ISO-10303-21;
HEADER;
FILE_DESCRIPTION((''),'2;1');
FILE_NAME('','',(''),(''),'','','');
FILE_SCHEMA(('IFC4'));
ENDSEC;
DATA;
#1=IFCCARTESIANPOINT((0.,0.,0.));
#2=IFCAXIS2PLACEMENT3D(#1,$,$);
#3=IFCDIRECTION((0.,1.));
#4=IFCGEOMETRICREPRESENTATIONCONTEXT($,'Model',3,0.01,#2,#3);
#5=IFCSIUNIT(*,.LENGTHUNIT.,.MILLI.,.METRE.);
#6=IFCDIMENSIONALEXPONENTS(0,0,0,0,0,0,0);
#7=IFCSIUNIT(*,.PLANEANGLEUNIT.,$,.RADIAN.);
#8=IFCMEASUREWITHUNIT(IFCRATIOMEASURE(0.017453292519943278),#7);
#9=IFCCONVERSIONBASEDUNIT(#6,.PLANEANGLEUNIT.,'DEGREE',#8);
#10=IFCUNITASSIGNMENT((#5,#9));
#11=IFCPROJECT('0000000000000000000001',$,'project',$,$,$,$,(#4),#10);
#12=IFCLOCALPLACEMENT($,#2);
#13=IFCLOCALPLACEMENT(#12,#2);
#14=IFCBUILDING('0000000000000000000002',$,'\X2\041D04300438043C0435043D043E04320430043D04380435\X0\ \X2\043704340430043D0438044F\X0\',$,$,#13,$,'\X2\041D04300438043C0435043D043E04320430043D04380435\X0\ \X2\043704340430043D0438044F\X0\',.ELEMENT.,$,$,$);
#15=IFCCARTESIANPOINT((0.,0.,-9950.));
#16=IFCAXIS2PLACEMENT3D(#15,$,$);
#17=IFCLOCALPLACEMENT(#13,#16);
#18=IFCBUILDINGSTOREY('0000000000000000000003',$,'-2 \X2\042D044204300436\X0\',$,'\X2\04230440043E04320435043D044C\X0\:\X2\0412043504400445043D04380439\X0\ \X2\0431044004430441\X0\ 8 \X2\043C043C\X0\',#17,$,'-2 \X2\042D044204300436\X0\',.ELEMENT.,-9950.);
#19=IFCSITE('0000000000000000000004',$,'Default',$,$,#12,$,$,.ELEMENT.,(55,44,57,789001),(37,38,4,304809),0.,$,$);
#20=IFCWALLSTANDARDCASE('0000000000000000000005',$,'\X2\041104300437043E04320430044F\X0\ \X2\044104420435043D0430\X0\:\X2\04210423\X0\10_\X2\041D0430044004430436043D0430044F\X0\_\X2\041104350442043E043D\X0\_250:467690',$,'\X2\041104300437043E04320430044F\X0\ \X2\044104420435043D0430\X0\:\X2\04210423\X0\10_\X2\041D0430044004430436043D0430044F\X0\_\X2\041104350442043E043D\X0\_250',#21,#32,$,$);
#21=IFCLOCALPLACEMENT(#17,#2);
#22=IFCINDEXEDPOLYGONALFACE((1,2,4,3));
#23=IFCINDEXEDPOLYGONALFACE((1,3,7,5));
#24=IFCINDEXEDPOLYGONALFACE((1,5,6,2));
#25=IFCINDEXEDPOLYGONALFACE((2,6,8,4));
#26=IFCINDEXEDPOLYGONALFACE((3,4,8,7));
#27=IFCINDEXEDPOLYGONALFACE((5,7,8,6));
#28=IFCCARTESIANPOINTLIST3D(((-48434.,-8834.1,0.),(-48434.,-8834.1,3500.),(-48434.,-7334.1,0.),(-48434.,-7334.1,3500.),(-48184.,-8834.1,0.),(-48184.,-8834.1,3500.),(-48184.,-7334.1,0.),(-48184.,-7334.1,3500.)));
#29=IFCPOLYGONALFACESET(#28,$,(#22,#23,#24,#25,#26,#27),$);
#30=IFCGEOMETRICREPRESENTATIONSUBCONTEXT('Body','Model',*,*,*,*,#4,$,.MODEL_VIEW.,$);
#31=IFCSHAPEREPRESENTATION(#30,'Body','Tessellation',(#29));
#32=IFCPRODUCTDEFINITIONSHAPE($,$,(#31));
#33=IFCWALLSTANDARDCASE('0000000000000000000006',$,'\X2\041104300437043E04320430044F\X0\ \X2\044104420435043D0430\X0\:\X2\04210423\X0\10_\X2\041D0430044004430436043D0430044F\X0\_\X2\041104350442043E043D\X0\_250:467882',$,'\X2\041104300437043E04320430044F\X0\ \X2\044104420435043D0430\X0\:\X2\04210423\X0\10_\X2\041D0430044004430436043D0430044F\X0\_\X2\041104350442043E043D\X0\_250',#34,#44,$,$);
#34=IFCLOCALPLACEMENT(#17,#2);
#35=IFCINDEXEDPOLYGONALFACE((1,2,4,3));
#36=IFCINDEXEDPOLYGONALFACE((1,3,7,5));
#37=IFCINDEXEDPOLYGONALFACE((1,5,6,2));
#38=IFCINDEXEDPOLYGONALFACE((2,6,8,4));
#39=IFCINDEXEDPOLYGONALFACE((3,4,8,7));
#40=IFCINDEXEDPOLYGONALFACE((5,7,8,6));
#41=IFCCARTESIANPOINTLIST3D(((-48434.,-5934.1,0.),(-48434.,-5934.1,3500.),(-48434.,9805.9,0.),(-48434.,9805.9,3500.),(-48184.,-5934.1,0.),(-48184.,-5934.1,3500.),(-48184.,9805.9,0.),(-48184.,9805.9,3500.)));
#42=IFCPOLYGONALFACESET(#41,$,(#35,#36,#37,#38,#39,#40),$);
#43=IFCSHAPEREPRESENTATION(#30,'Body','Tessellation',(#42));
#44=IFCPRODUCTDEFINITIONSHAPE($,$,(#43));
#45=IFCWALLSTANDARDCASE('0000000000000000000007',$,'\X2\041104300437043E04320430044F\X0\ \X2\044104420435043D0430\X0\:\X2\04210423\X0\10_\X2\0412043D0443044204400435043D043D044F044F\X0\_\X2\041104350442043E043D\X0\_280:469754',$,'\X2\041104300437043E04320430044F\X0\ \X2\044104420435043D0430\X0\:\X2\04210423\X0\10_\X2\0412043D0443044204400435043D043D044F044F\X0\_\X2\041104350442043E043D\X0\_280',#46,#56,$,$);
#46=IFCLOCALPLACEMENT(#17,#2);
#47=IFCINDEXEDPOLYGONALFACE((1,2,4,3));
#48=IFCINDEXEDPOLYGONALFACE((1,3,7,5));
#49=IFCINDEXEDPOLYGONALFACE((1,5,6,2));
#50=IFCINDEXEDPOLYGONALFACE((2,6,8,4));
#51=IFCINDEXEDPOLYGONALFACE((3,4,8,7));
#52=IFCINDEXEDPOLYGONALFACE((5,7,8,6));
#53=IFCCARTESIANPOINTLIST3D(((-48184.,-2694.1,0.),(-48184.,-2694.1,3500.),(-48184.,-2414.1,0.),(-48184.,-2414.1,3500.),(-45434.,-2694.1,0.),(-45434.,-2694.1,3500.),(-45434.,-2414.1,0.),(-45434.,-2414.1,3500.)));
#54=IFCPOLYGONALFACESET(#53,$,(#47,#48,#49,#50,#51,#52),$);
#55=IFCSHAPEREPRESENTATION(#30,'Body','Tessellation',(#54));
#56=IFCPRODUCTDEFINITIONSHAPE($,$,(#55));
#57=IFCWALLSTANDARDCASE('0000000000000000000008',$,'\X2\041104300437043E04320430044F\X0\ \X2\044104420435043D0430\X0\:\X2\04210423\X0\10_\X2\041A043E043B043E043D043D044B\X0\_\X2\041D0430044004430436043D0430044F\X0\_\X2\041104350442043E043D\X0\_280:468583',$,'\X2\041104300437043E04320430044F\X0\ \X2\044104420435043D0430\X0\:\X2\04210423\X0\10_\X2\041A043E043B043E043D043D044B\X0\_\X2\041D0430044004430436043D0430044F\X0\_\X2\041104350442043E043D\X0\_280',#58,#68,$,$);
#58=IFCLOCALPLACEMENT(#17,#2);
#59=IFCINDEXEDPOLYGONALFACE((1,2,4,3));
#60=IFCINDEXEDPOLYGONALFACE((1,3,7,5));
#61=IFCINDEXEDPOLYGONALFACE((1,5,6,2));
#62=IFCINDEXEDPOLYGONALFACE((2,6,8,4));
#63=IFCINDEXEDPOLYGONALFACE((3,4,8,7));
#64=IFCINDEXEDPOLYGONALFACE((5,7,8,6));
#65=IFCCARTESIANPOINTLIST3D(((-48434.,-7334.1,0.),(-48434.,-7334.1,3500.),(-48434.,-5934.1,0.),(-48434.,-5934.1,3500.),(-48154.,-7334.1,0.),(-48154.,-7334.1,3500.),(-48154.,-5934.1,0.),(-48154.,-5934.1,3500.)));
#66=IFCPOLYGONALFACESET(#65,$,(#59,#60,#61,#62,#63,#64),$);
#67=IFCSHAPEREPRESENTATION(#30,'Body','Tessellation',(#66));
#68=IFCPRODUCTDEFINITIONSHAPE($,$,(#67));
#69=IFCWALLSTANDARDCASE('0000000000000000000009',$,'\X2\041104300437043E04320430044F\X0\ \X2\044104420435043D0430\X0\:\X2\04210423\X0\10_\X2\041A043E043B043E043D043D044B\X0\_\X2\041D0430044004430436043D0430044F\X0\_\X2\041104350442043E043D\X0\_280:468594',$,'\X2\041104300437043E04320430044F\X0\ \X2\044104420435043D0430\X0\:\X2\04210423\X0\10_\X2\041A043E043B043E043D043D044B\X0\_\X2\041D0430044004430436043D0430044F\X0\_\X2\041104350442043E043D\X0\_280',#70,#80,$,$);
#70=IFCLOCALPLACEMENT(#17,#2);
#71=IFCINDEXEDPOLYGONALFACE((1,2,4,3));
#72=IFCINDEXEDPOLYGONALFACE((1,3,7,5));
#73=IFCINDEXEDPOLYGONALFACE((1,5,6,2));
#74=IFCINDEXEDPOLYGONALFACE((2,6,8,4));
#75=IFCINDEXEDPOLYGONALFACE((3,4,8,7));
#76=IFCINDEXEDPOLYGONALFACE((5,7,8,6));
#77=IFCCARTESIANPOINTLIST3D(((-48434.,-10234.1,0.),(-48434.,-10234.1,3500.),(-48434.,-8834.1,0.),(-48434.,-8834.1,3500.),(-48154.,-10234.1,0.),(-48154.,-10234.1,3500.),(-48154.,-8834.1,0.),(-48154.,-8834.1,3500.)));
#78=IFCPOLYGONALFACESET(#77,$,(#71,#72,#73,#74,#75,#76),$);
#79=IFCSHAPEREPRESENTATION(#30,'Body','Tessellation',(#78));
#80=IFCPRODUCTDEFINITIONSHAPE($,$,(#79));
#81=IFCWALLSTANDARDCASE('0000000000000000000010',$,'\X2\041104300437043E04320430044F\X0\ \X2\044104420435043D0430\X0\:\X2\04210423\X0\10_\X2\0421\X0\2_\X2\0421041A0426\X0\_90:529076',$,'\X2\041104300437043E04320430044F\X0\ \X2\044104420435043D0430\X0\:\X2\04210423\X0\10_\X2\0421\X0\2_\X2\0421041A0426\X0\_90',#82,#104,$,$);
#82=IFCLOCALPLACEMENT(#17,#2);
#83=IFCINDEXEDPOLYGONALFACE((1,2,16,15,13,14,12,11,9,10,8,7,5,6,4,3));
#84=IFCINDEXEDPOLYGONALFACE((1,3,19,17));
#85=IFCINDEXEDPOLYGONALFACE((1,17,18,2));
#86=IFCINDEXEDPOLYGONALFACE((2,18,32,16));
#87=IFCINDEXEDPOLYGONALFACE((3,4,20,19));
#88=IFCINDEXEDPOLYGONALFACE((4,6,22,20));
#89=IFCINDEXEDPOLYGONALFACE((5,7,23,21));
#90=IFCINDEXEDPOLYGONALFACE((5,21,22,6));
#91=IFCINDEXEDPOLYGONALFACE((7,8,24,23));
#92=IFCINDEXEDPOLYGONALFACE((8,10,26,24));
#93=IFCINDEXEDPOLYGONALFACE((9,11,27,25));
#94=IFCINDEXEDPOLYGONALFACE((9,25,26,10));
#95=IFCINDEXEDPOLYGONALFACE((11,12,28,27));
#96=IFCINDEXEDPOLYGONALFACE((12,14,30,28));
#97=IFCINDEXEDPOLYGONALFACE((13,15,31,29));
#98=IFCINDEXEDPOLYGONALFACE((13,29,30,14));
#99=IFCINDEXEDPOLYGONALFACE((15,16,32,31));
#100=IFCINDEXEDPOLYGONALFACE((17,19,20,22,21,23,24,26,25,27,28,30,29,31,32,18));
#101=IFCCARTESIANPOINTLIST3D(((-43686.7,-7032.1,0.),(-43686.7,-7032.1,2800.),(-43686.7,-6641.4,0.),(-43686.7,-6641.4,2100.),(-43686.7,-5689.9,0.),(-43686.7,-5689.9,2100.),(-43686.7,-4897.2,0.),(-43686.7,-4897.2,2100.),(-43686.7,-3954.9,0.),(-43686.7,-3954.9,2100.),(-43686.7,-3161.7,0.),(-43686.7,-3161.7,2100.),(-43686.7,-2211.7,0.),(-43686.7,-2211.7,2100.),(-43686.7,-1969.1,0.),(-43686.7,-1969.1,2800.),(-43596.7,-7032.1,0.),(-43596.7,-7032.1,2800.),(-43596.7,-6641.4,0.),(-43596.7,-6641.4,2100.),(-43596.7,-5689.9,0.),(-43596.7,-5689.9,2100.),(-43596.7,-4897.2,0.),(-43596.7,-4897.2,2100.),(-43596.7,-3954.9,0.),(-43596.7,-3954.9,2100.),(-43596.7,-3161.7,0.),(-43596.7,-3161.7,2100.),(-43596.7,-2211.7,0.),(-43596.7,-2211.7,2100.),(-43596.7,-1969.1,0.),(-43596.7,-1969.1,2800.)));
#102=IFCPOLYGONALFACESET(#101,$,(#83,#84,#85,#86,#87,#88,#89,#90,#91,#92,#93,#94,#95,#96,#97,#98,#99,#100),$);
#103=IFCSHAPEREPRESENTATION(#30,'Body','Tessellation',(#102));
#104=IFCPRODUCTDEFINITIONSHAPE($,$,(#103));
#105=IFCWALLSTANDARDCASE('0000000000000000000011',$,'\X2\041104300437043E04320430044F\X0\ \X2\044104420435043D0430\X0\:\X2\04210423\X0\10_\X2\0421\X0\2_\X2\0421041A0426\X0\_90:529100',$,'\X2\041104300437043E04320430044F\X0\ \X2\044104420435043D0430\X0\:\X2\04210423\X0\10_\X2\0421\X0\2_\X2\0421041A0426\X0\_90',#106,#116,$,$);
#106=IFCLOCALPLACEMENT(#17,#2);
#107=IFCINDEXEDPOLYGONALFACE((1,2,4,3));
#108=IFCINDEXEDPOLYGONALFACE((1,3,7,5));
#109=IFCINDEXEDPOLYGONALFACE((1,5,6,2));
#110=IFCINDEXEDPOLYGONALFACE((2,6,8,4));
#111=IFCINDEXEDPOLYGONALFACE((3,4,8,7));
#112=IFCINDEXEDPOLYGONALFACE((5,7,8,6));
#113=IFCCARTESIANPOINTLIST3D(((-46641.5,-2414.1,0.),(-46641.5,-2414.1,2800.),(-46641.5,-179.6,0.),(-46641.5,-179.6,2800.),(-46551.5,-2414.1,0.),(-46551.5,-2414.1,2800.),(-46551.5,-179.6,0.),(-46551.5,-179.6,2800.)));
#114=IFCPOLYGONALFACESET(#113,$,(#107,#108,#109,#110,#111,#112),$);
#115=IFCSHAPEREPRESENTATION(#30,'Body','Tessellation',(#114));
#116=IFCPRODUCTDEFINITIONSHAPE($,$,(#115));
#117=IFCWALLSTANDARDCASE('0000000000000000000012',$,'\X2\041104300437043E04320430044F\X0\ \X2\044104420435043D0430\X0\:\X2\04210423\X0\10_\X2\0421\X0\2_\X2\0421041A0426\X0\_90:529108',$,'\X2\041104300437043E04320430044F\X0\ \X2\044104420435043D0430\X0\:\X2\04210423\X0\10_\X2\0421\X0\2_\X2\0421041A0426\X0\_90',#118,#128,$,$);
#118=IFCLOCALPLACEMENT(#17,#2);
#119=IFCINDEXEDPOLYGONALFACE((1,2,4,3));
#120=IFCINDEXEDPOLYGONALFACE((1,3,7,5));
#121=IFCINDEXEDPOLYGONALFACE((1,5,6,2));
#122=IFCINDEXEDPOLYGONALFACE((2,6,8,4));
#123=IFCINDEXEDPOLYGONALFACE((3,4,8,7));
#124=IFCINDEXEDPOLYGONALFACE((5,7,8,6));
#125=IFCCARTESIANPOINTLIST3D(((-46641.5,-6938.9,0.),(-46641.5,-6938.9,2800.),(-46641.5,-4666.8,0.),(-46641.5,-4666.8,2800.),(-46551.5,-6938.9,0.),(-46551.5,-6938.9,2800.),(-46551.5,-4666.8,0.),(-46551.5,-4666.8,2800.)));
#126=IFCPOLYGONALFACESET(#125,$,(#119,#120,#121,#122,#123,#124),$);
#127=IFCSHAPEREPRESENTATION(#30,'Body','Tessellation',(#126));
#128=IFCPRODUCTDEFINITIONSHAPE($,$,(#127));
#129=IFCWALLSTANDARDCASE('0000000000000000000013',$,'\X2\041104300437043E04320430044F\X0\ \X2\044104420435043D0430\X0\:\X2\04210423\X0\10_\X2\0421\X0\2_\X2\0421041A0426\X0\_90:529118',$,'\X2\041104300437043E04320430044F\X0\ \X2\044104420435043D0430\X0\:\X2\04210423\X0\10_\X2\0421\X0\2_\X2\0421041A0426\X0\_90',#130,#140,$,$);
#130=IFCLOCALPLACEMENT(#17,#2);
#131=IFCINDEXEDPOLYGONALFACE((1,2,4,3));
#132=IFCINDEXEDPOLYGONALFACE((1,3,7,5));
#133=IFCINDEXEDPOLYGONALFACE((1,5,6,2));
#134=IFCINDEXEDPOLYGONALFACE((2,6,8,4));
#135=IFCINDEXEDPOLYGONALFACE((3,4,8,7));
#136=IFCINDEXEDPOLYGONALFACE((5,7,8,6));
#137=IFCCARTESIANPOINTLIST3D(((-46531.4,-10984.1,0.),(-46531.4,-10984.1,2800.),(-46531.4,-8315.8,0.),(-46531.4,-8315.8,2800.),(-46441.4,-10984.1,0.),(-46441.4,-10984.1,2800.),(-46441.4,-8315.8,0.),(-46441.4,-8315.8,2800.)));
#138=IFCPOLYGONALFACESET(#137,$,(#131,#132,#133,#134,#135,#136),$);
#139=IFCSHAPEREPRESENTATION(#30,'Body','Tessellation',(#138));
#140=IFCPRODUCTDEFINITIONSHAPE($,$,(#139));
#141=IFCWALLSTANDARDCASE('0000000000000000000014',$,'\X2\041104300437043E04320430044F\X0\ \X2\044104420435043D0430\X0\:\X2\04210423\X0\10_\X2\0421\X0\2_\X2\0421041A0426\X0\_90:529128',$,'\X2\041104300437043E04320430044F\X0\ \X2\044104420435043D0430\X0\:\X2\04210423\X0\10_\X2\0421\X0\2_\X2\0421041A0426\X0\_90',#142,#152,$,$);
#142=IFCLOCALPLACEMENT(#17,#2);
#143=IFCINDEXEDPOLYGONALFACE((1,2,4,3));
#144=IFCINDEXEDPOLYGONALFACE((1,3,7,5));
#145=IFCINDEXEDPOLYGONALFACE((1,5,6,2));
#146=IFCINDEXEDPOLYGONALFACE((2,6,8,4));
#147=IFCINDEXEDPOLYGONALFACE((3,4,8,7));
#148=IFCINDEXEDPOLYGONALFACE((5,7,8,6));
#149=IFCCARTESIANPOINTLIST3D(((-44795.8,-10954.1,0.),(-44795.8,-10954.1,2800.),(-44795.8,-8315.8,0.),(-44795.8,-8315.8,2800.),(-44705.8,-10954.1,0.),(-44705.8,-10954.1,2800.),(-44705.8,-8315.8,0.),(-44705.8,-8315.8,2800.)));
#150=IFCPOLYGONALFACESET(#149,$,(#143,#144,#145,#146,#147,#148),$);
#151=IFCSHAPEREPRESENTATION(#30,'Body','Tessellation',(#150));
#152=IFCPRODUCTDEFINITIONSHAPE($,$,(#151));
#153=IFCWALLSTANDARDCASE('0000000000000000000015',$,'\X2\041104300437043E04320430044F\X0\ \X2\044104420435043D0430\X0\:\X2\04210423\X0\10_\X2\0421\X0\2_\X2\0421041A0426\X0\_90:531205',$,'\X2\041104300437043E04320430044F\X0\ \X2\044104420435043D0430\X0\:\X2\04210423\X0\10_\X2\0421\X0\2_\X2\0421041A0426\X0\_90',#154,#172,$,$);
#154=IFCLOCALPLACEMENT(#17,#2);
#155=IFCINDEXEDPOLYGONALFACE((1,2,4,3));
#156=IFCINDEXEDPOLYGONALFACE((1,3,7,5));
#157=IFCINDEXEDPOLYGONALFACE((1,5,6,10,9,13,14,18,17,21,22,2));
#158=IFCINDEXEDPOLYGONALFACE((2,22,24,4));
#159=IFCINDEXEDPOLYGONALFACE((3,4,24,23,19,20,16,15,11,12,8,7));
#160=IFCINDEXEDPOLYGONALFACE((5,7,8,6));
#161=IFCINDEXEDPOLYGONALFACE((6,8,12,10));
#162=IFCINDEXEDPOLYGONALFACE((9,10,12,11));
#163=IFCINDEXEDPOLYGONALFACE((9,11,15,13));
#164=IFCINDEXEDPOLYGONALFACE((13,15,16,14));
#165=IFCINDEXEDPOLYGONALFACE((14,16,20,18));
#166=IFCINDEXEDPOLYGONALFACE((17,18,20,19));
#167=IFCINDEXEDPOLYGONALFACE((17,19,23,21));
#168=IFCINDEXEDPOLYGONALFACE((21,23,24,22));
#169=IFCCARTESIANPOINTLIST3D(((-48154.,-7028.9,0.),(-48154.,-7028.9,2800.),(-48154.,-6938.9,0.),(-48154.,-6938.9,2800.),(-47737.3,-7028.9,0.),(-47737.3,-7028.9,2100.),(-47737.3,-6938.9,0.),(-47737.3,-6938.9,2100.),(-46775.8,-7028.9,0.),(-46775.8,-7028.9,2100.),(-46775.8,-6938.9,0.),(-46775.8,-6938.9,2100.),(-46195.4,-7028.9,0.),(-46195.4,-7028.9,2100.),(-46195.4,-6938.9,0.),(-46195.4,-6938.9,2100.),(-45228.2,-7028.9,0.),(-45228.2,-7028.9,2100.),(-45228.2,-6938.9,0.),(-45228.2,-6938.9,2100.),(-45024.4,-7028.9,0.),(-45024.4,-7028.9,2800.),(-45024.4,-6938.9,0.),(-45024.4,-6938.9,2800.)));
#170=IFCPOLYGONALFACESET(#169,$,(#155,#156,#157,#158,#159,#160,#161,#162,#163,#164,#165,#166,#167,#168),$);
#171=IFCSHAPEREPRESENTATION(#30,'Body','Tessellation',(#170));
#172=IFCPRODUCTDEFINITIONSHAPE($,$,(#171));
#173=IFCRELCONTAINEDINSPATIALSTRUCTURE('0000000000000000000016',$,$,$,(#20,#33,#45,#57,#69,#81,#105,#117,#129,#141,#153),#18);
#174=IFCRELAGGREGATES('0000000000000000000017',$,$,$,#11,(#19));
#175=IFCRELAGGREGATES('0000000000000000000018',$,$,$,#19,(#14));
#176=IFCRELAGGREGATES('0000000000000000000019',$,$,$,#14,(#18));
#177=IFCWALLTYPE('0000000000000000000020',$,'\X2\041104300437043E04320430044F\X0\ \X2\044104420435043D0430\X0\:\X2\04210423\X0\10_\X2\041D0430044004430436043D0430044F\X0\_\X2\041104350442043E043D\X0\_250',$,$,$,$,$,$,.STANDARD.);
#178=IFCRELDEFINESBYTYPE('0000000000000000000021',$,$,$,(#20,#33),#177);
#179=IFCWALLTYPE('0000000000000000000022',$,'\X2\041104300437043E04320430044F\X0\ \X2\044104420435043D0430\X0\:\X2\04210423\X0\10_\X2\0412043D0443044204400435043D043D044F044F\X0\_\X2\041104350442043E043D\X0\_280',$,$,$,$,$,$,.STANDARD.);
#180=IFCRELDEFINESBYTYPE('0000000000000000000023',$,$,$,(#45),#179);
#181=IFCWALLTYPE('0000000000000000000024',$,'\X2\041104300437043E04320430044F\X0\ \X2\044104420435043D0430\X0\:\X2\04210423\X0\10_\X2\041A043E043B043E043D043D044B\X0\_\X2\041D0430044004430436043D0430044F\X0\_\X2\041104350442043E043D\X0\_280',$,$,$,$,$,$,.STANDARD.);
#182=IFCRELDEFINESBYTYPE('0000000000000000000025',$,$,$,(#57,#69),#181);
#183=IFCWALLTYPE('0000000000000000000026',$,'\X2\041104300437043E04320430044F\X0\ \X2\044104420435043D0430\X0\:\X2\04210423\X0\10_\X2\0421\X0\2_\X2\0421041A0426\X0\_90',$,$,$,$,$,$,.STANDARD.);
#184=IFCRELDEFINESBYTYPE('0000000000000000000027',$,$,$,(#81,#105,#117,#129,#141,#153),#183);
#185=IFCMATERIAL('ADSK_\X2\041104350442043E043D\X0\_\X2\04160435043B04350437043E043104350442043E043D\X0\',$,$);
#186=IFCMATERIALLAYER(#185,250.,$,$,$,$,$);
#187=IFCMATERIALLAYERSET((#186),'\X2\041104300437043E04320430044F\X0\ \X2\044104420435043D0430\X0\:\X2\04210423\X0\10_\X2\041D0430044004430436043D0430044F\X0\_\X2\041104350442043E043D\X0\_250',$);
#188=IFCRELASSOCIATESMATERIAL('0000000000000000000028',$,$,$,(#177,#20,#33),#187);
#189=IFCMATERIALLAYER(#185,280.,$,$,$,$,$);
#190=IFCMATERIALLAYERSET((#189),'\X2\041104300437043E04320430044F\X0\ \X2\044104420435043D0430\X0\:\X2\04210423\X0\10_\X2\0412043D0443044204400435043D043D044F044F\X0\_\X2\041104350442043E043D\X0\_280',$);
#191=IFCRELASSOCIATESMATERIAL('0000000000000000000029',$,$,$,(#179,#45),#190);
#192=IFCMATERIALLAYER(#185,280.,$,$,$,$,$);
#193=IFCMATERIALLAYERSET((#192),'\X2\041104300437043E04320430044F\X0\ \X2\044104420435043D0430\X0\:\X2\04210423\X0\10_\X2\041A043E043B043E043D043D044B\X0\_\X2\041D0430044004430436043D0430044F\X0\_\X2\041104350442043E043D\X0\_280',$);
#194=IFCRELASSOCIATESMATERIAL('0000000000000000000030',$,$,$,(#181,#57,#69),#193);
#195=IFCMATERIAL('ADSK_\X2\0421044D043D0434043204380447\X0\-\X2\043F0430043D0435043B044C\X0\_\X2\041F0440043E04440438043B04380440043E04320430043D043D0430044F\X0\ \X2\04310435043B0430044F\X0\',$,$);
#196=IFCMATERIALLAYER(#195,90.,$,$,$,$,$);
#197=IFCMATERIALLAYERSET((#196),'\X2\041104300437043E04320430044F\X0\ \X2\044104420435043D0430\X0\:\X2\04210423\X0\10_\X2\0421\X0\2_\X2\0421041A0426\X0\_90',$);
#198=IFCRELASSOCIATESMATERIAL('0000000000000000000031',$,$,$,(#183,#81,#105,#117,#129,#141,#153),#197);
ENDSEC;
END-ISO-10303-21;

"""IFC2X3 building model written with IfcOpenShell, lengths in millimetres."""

from ifc_helpers import new_model, entity, si_unit, converted_unit, direction, frame, frame_2d, origin, place, context, subcontext, project, spatial, rectangle, extrude, material, layer, layer_set, layer_usage, type_object, element, save


model = new_model("IFC2X3")

# Units and contexts
model_context = context("Model", 3, precision=0.01, world=origin(), true_north=direction((0.0, 1.0)))
body_context = subcontext(model_context, "Body", "Model", "MODEL_VIEW")
ifc_project = project(units=[si_unit("LENGTHUNIT", "METRE", prefix="MILLI"), converted_unit("PLANEANGLEUNIT", "DEGREE", entity("IfcRatioMeasure", 0.017453292519943278), si_unit("PLANEANGLEUNIT", "RADIAN"), dimensions=[0, 0, 0, 0, 0, 0, 0])], contexts=[model_context])

# Site, building, storey
site_placement = place(None, origin())
site = spatial("IfcSite", under=ifc_project, at=site_placement, Name="Default", CompositionType="ELEMENT", RefLatitude=(55, 44, 57, 789001), RefLongitude=(37, 38, 4, 304809), RefElevation=0.0)
building_placement = place(site_placement, origin())
building = spatial("IfcBuilding", under=site, at=building_placement, Name="Наименование здания", LongName="Наименование здания", CompositionType="ELEMENT")
storey_placement = place(building_placement, frame((0.0, 0.0, -9950.0)))
storey = spatial("IfcBuildingStorey", under=building, at=storey_placement, Name="-2 Этаж", ObjectType="Уровень:Верхний брус 8 мм", LongName="-2 Этаж", CompositionType="ELEMENT", Elevation=-9950.0)

# Shared definitions
ifc_material_1 = material(Name="ADSK_Бетон_Железобетон")

# Walls
ifc_layer_1 = layer(ifc_material_1, 250.0)
ifc_layer_set_1 = layer_set([ifc_layer_1], Name="Базовая стена:СУ10_Наружная_Бетон_250")
ifc_layer_usage_1 = layer_usage(ifc_layer_set_1, "AXIS2", "NEGATIVE", 125.0)
wall_type_1 = type_object("IfcWallType", Name="Базовая стена:СУ10_Наружная_Бетон_250", PredefinedType="STANDARD", material=ifc_layer_set_1)
wall_1_placement = place(storey_placement, frame((-48309.0, -8834.1, 0.0), z_axis=(0.0, 0.0, 1.0), x_axis=(0.0, 1.0, 0.0)))
element("IfcWallStandardCase", 1, at=wall_1_placement, inside=storey, type_object=wall_type_1, material=ifc_layer_usage_1, Name="Базовая стена:СУ10_Наружная_Бетон_250:467690", ObjectType="Базовая стена:СУ10_Наружная_Бетон_250", context=body_context, shape_type="SweptSolid", body=[
    extrude(rectangle(XDim=1500.0, YDim=250.0, at=frame_2d((750.0, 0.0), x_axis=(-1.0, 0.0))), origin(), (0.0, 0.0, 1.0), 3500.0),
])
wall_2_placement = place(storey_placement, frame((-48309.0, -5934.1, 0.0), z_axis=(0.0, 0.0, 1.0), x_axis=(0.0, 1.0, 0.0)))
element("IfcWallStandardCase", 2, at=wall_2_placement, inside=storey, type_object=wall_type_1, material=ifc_layer_usage_1, Name="Базовая стена:СУ10_Наружная_Бетон_250:467882", ObjectType="Базовая стена:СУ10_Наружная_Бетон_250", context=body_context, shape_type="SweptSolid", body=[
    extrude(rectangle(XDim=15740.0, YDim=250.0, at=frame_2d((7870.0, 0.0), x_axis=(-1.0, 0.0))), origin(), (0.0, 0.0, 1.0), 3500.0),
])
ifc_layer_2 = layer(ifc_material_1, 280.0)
ifc_layer_set_2 = layer_set([ifc_layer_2], Name="Базовая стена:СУ10_Внутренняя_Бетон_280")
ifc_layer_usage_2 = layer_usage(ifc_layer_set_2, "AXIS2", "NEGATIVE", 140.0)
wall_type_2 = type_object("IfcWallType", Name="Базовая стена:СУ10_Внутренняя_Бетон_280", PredefinedType="STANDARD", material=ifc_layer_set_2)
wall_3_placement = place(storey_placement, frame((-45434.0, -2554.1, 0.0), z_axis=(0.0, 0.0, 1.0), x_axis=(-1.0, 0.0, 0.0)))
element("IfcWallStandardCase", 3, at=wall_3_placement, inside=storey, type_object=wall_type_2, material=ifc_layer_usage_2, Name="Базовая стена:СУ10_Внутренняя_Бетон_280:469754", ObjectType="Базовая стена:СУ10_Внутренняя_Бетон_280", context=body_context, shape_type="SweptSolid", body=[
    extrude(rectangle(XDim=2750.0, YDim=280.0, at=frame_2d((1375.0, 0.0), x_axis=(-1.0, 0.0))), origin(), (0.0, 0.0, 1.0), 3500.0),
])
ifc_layer_3 = layer(ifc_material_1, 280.0)
ifc_layer_set_3 = layer_set([ifc_layer_3], Name="Базовая стена:СУ10_Колонны_Наружная_Бетон_280")
ifc_layer_usage_3 = layer_usage(ifc_layer_set_3, "AXIS2", "NEGATIVE", 140.0)
wall_type_3 = type_object("IfcWallType", Name="Базовая стена:СУ10_Колонны_Наружная_Бетон_280", PredefinedType="STANDARD", material=ifc_layer_set_3)
wall_4_placement = place(storey_placement, frame((-48294.0, -7334.1, 0.0), z_axis=(0.0, 0.0, 1.0), x_axis=(0.0, 1.0, 0.0)))
element("IfcWallStandardCase", 4, at=wall_4_placement, inside=storey, type_object=wall_type_3, material=ifc_layer_usage_3, Name="Базовая стена:СУ10_Колонны_Наружная_Бетон_280:468583", ObjectType="Базовая стена:СУ10_Колонны_Наружная_Бетон_280", context=body_context, shape_type="SweptSolid", body=[
    extrude(rectangle(XDim=1400.0, YDim=280.0, at=frame_2d((700.0, 0.0), x_axis=(-1.0, 0.0))), origin(), (0.0, 0.0, 1.0), 3500.0),
])
wall_5_placement = place(storey_placement, frame((-48294.0, -10234.1, 0.0), z_axis=(0.0, 0.0, 1.0), x_axis=(0.0, 1.0, 0.0)))
element("IfcWallStandardCase", 5, at=wall_5_placement, inside=storey, type_object=wall_type_3, material=ifc_layer_usage_3, Name="Базовая стена:СУ10_Колонны_Наружная_Бетон_280:468594", ObjectType="Базовая стена:СУ10_Колонны_Наружная_Бетон_280", context=body_context, shape_type="SweptSolid", body=[
    extrude(rectangle(XDim=1400.0, YDim=280.0, at=frame_2d((700.0, 0.0), x_axis=(-1.0, 0.0))), origin(), (0.0, 0.0, 1.0), 3500.0),
])

# Wall, openings
ifc_material_2 = material(Name="ADSK_Сэндвич-панель_Профилированная белая")
ifc_layer_4 = layer(ifc_material_2, 90.0)
ifc_layer_set_4 = layer_set([ifc_layer_4], Name="Базовая стена:СУ10_С2_СКЦ_90")
ifc_layer_usage_4 = layer_usage(ifc_layer_set_4, "AXIS2", "NEGATIVE", 45.0)
wall_type_4 = type_object("IfcWallType", Name="Базовая стена:СУ10_С2_СКЦ_90", PredefinedType="STANDARD", material=ifc_layer_set_4)
wall_6_placement = place(storey_placement, frame((-43641.7, -1969.1, 0.0), z_axis=(0.0, 0.0, 1.0), x_axis=(0.0, -1.0, 0.0)))
wall_6 = element("IfcWallStandardCase", 6, at=wall_6_placement, inside=storey, type_object=wall_type_4, material=ifc_layer_usage_4, Name="Базовая стена:СУ10_С2_СКЦ_90:529076", ObjectType="Базовая стена:СУ10_С2_СКЦ_90", context=body_context, shape_type="SweptSolid", body=[
    extrude(rectangle(XDim=5062.9, YDim=90.0, at=frame_2d((2531.5, 0.0), x_axis=(1.0, 0.0))), origin(), (0.0, 0.0, 1.0), 2800.0),
])
opening_1_placement = place(wall_6_placement, origin())
element("IfcOpeningElement", 7, at=opening_1_placement, cuts=wall_6, ObjectType="Opening", context=body_context, shape_type="SweptSolid", body=[
    extrude(rectangle(XDim=2100.0, YDim=950.0, at=frame_2d((0.0, 0.0), x_axis=(1.0, 0.0))), frame((717.6, -45.0, 1050.0), z_axis=(0.0, 1.0, 0.0), x_axis=(0.0, 0.0, -1.0)), (0.0, 0.0, 1.0), 90.0),
])
opening_2_placement = place(wall_6_placement, origin())
element("IfcOpeningElement", 8, at=opening_2_placement, cuts=wall_6, ObjectType="Opening", context=body_context, shape_type="SweptSolid", body=[
    extrude(rectangle(XDim=2100.0, YDim=942.3, at=frame_2d((0.0, 0.0), x_axis=(1.0, 0.0))), frame((2456.9, -45.0, 1050.0), z_axis=(0.0, 1.0, 0.0), x_axis=(0.0, 0.0, -1.0)), (0.0, 0.0, 1.0), 90.0),
])
opening_3_placement = place(wall_6_placement, origin())
element("IfcOpeningElement", 9, at=opening_3_placement, cuts=wall_6, ObjectType="Opening", context=body_context, shape_type="SweptSolid", body=[
    extrude(rectangle(XDim=2100.0, YDim=951.5, at=frame_2d((0.0, 0.0), x_axis=(1.0, 0.0))), frame((4196.5, -45.0, 1050.0), z_axis=(0.0, 1.0, 0.0), x_axis=(0.0, 0.0, -1.0)), (0.0, 0.0, 1.0), 90.0),
])

# Walls
wall_7_placement = place(storey_placement, frame((-46596.5, -179.6, 0.0), z_axis=(0.0, 0.0, 1.0), x_axis=(0.0, -1.0, 0.0)))
element("IfcWallStandardCase", 10, at=wall_7_placement, inside=storey, type_object=wall_type_4, material=ifc_layer_usage_4, Name="Базовая стена:СУ10_С2_СКЦ_90:529100", ObjectType="Базовая стена:СУ10_С2_СКЦ_90", context=body_context, shape_type="SweptSolid", body=[
    extrude(rectangle(XDim=2234.5, YDim=90.0, at=frame_2d((1117.2, 0.0), x_axis=(-1.0, 0.0))), origin(), (0.0, 0.0, 1.0), 2800.0),
])
wall_8_placement = place(storey_placement, frame((-46596.5, -4666.8, 0.0), z_axis=(0.0, 0.0, 1.0), x_axis=(0.0, -1.0, 0.0)))
element("IfcWallStandardCase", 11, at=wall_8_placement, inside=storey, type_object=wall_type_4, material=ifc_layer_usage_4, Name="Базовая стена:СУ10_С2_СКЦ_90:529108", ObjectType="Базовая стена:СУ10_С2_СКЦ_90", context=body_context, shape_type="SweptSolid", body=[
    extrude(rectangle(XDim=2272.1, YDim=90.0, at=frame_2d((1136.1, 0.0), x_axis=(-1.0, 0.0))), origin(), (0.0, 0.0, 1.0), 2800.0),
])
wall_9_placement = place(storey_placement, frame((-46486.4, -8315.8, 0.0), z_axis=(0.0, 0.0, 1.0), x_axis=(0.0, -1.0, 0.0)))
element("IfcWallStandardCase", 12, at=wall_9_placement, inside=storey, type_object=wall_type_4, material=ifc_layer_usage_4, Name="Базовая стена:СУ10_С2_СКЦ_90:529118", ObjectType="Базовая стена:СУ10_С2_СКЦ_90", context=body_context, shape_type="SweptSolid", body=[
    extrude(rectangle(XDim=2668.3, YDim=90.0, at=frame_2d((1334.1, 0.0), x_axis=(-1.0, 0.0))), origin(), (0.0, 0.0, 1.0), 2800.0),
])
wall_10_placement = place(storey_placement, frame((-44750.8, -8315.8, 0.0), z_axis=(0.0, 0.0, 1.0), x_axis=(0.0, -1.0, 0.0)))
element("IfcWallStandardCase", 13, at=wall_10_placement, inside=storey, type_object=wall_type_4, material=ifc_layer_usage_4, Name="Базовая стена:СУ10_С2_СКЦ_90:529128", ObjectType="Базовая стена:СУ10_С2_СКЦ_90", context=body_context, shape_type="SweptSolid", body=[
    extrude(rectangle(XDim=2638.3, YDim=90.0, at=frame_2d((1319.1, 0.0), x_axis=(-1.0, 0.0))), origin(), (0.0, 0.0, 1.0), 2800.0),
])

# Wall, openings
wall_11_placement = place(storey_placement, frame((-45024.4, -6983.9, 0.0), z_axis=(0.0, 0.0, 1.0), x_axis=(-1.0, 0.0, 0.0)))
wall_11 = element("IfcWallStandardCase", 14, at=wall_11_placement, inside=storey, type_object=wall_type_4, material=ifc_layer_usage_4, Name="Базовая стена:СУ10_С2_СКЦ_90:531205", ObjectType="Базовая стена:СУ10_С2_СКЦ_90", context=body_context, shape_type="SweptSolid", body=[
    extrude(rectangle(XDim=3129.6, YDim=90.0, at=frame_2d((1564.8, 0.0), x_axis=(1.0, 0.0))), origin(), (0.0, 0.0, 1.0), 2800.0),
])
opening_4_placement = place(wall_11_placement, origin())
element("IfcOpeningElement", 15, at=opening_4_placement, cuts=wall_11, ObjectType="Opening", context=body_context, shape_type="SweptSolid", body=[
    extrude(rectangle(XDim=2100.0, YDim=961.5, at=frame_2d((0.0, 0.0), x_axis=(1.0, 0.0))), frame((2232.2, -45.0, 1050.0), z_axis=(0.0, 1.0, 0.0), x_axis=(0.0, 0.0, -1.0)), (0.0, 0.0, 1.0), 90.0),
])
opening_5_placement = place(wall_11_placement, origin())
element("IfcOpeningElement", 16, at=opening_5_placement, cuts=wall_11, ObjectType="Opening", context=body_context, shape_type="SweptSolid", body=[
    extrude(rectangle(XDim=2100.0, YDim=967.2, at=frame_2d((0.0, 0.0), x_axis=(1.0, 0.0))), frame((687.4, -45.0, 1050.0), z_axis=(0.0, 1.0, 0.0), x_axis=(0.0, 0.0, -1.0)), (0.0, 0.0, 1.0), 90.0),
])

save(model, "model.ifc")
